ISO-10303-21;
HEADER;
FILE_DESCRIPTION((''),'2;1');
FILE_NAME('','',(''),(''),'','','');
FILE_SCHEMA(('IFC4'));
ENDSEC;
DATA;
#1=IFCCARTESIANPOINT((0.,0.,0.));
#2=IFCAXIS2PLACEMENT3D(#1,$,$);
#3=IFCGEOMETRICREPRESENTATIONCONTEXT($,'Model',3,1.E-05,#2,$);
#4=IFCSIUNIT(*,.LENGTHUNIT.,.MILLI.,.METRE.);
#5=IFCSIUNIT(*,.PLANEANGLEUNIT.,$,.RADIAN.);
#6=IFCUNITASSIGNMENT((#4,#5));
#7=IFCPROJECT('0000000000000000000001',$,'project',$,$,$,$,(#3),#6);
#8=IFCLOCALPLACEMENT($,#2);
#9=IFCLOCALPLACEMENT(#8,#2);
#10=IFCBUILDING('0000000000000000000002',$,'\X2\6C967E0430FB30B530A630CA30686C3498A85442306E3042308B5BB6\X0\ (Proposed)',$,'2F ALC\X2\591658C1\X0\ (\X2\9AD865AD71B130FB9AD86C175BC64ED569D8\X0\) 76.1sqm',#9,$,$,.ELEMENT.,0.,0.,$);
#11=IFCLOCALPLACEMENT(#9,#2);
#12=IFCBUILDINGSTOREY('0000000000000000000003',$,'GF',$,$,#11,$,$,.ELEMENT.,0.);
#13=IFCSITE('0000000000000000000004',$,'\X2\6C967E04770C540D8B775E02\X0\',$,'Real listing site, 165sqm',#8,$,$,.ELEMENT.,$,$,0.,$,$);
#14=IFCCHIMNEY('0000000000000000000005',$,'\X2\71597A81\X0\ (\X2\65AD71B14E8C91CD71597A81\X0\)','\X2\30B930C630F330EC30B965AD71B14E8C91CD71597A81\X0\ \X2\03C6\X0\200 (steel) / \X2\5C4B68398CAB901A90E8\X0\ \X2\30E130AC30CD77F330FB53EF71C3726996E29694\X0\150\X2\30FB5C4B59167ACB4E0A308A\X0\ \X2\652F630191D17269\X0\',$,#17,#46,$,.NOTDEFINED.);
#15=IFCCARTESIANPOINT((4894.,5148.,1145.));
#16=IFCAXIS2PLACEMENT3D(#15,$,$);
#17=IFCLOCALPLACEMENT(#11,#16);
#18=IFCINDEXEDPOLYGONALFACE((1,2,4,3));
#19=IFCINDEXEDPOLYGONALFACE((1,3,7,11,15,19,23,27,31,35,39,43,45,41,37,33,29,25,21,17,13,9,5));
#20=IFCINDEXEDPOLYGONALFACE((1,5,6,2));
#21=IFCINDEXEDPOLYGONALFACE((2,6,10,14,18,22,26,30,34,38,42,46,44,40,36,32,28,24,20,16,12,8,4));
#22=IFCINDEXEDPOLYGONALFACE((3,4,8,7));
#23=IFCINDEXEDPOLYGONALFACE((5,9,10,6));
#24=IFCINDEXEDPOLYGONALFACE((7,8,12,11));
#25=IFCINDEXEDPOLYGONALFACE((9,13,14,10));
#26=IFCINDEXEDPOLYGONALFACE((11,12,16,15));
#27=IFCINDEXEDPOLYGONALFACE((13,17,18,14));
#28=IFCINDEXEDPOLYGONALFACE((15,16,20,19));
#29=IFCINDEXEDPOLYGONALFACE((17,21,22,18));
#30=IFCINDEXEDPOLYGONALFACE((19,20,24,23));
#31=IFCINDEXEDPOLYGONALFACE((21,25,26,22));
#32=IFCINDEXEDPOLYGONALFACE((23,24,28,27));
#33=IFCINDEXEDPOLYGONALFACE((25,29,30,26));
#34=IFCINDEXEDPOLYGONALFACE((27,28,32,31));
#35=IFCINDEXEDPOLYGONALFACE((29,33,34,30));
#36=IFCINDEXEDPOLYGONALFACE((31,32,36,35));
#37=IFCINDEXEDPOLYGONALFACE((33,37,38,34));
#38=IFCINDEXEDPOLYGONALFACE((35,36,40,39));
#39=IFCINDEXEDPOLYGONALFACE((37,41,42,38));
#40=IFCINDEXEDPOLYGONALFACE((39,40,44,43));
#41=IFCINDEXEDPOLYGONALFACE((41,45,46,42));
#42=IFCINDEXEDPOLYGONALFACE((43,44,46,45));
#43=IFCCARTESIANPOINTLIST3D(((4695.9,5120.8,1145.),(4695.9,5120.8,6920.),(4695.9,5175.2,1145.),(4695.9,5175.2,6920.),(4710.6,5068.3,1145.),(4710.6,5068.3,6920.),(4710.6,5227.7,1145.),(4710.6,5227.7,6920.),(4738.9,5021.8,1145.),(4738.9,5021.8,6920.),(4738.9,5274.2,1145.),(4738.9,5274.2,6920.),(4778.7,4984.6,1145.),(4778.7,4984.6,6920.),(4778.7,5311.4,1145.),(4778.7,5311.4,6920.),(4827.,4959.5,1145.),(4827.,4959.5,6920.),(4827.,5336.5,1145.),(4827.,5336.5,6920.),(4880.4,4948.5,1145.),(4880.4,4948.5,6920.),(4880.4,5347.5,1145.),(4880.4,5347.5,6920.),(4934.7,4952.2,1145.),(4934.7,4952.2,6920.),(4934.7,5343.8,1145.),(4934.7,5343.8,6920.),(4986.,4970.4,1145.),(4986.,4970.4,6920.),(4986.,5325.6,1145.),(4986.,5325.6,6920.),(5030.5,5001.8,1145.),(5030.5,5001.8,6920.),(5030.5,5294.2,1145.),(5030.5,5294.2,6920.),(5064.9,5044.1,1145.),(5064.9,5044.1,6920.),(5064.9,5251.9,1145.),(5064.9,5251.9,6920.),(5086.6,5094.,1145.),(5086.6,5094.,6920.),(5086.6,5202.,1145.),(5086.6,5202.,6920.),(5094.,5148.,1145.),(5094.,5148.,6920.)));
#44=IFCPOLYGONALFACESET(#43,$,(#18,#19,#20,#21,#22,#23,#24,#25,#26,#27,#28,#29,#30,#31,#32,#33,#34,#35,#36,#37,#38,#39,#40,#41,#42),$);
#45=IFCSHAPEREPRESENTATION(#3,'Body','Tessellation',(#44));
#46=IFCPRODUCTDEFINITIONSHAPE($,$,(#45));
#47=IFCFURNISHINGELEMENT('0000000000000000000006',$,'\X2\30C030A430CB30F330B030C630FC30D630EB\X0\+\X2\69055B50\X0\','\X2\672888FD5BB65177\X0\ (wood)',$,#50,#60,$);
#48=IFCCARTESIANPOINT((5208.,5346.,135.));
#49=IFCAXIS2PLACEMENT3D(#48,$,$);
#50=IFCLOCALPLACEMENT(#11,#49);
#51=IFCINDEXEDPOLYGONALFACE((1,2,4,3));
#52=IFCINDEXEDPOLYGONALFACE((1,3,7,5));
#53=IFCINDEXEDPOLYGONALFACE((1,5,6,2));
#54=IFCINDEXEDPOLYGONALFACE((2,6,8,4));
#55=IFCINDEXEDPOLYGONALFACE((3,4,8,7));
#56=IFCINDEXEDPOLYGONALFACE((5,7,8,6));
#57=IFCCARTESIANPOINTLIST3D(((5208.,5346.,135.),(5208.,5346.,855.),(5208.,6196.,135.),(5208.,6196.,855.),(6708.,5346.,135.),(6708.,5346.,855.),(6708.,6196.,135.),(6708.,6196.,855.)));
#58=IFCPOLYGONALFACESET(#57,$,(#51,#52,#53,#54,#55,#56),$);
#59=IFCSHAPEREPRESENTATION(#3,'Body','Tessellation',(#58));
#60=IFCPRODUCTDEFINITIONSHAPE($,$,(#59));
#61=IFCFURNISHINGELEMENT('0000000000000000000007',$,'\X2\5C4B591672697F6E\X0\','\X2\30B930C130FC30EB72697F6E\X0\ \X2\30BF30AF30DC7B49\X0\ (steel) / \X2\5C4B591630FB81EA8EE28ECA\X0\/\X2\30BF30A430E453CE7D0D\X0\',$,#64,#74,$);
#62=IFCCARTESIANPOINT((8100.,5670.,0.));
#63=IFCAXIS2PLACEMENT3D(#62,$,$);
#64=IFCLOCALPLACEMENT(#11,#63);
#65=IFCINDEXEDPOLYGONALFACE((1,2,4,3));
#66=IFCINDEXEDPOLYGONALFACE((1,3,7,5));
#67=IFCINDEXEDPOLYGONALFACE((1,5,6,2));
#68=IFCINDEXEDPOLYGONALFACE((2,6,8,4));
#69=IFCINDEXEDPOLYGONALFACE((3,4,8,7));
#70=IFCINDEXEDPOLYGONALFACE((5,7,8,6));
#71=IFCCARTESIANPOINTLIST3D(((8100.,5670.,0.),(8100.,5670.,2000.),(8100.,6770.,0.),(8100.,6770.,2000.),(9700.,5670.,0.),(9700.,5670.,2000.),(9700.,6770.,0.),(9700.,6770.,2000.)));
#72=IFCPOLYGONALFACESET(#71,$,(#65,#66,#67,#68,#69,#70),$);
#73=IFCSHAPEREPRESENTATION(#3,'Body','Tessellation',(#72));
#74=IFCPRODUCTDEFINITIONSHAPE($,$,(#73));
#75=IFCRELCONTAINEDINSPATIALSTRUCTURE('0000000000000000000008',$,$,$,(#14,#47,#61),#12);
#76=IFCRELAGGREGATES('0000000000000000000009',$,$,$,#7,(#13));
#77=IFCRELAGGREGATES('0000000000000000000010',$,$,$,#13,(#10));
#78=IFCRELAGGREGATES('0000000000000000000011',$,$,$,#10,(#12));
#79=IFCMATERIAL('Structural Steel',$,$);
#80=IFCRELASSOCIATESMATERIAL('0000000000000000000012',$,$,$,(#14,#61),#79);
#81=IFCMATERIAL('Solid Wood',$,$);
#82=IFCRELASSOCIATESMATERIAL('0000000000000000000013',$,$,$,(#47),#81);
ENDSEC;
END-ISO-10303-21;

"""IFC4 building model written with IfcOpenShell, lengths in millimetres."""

from ifc_helpers import new_model, si_unit, frame, frame_2d, origin, origin_2d, place, context, project, spatial, rectangle, circle, extrude, material, element, save


model = new_model("IFC4")

# Units and contexts
model_context = context("Model", 3, precision=1e-05, world=origin())
ifc_project = project(units=[si_unit("LENGTHUNIT", "METRE", prefix="MILLI"), si_unit("PLANEANGLEUNIT", "RADIAN")], contexts=[model_context])

# Site, building, storey
site_placement = place(None, origin())
site = spatial("IfcSite", under=ifc_project, at=site_placement, Name="沖縄県名護市", ObjectType="Real listing site, 165sqm", CompositionType="ELEMENT", RefElevation=0.0)
building_placement = place(site_placement, origin())
building = spatial("IfcBuilding", under=site, at=building_placement, Name="沖縄・サウナと水風呂のある家 (Proposed)", ObjectType="2F ALC外壁 (高断熱・高気密仕様) 76.1sqm", CompositionType="ELEMENT", ElevationOfRefHeight=0.0, ElevationOfTerrain=0.0)
storey_placement = place(building_placement, origin())
storey = spatial("IfcBuildingStorey", under=building, at=storey_placement, Name="GF", CompositionType="ELEMENT", Elevation=0.0)

# Shared definitions
ifc_material_1 = material(Name="Solid Wood")

# Shared definitions
ifc_material_2 = material(Name="Structural Steel")

# Chimney
chimney_placement = place(storey_placement, frame((4894.0, 5148.0, 1145.0)))
element("IfcChimney", 1, at=chimney_placement, inside=storey, material=ifc_material_2, Name="煙突 (断熱二重煙突)", Description="ステンレス断熱二重煙突 φ200 (steel) / 屋根貫通部 メガネ石・可燃物離隔150・屋外立上り 支持金物", PredefinedType="NOTDEFINED", context=model_context, shape_type="SweptSolid", body=[
    extrude(circle(Radius=200.0, at=origin_2d()), frame((4894.0, 5148.0, 1145.0)), (0.0, 0.0, 1.0), 5775.0),
])

# Furnishing elements
furnishing_1_placement = place(storey_placement, frame((5208.0, 5346.0, 135.0)))
element("IfcFurnishingElement", 2, at=furnishing_1_placement, inside=storey, material=ifc_material_1, Name="ダイニングテーブル+椅子", Description="木製家具 (wood)", context=model_context, shape_type="SweptSolid", body=[
    extrude(rectangle(XDim=1500.0, YDim=850.0, at=frame_2d((750.0, 425.0))), frame((5208.0, 5346.0, 135.0)), (0.0, 0.0, 1.0), 720.0),
])
furnishing_2_placement = place(storey_placement, frame((8100.0, 5670.0, 0.0)))
element("IfcFurnishingElement", 3, at=furnishing_2_placement, inside=storey, material=ifc_material_2, Name="屋外物置", Description="スチール物置 タクボ等 (steel) / 屋外・自転車/タイヤ収納", context=model_context, shape_type="SweptSolid", body=[
    extrude(rectangle(XDim=1600.0, YDim=1100.0, at=frame_2d((800.0, 550.0))), frame((8100.0, 5670.0, 0.0)), (0.0, 0.0, 1.0), 2000.0),
])

save(model, "model.ifc")
